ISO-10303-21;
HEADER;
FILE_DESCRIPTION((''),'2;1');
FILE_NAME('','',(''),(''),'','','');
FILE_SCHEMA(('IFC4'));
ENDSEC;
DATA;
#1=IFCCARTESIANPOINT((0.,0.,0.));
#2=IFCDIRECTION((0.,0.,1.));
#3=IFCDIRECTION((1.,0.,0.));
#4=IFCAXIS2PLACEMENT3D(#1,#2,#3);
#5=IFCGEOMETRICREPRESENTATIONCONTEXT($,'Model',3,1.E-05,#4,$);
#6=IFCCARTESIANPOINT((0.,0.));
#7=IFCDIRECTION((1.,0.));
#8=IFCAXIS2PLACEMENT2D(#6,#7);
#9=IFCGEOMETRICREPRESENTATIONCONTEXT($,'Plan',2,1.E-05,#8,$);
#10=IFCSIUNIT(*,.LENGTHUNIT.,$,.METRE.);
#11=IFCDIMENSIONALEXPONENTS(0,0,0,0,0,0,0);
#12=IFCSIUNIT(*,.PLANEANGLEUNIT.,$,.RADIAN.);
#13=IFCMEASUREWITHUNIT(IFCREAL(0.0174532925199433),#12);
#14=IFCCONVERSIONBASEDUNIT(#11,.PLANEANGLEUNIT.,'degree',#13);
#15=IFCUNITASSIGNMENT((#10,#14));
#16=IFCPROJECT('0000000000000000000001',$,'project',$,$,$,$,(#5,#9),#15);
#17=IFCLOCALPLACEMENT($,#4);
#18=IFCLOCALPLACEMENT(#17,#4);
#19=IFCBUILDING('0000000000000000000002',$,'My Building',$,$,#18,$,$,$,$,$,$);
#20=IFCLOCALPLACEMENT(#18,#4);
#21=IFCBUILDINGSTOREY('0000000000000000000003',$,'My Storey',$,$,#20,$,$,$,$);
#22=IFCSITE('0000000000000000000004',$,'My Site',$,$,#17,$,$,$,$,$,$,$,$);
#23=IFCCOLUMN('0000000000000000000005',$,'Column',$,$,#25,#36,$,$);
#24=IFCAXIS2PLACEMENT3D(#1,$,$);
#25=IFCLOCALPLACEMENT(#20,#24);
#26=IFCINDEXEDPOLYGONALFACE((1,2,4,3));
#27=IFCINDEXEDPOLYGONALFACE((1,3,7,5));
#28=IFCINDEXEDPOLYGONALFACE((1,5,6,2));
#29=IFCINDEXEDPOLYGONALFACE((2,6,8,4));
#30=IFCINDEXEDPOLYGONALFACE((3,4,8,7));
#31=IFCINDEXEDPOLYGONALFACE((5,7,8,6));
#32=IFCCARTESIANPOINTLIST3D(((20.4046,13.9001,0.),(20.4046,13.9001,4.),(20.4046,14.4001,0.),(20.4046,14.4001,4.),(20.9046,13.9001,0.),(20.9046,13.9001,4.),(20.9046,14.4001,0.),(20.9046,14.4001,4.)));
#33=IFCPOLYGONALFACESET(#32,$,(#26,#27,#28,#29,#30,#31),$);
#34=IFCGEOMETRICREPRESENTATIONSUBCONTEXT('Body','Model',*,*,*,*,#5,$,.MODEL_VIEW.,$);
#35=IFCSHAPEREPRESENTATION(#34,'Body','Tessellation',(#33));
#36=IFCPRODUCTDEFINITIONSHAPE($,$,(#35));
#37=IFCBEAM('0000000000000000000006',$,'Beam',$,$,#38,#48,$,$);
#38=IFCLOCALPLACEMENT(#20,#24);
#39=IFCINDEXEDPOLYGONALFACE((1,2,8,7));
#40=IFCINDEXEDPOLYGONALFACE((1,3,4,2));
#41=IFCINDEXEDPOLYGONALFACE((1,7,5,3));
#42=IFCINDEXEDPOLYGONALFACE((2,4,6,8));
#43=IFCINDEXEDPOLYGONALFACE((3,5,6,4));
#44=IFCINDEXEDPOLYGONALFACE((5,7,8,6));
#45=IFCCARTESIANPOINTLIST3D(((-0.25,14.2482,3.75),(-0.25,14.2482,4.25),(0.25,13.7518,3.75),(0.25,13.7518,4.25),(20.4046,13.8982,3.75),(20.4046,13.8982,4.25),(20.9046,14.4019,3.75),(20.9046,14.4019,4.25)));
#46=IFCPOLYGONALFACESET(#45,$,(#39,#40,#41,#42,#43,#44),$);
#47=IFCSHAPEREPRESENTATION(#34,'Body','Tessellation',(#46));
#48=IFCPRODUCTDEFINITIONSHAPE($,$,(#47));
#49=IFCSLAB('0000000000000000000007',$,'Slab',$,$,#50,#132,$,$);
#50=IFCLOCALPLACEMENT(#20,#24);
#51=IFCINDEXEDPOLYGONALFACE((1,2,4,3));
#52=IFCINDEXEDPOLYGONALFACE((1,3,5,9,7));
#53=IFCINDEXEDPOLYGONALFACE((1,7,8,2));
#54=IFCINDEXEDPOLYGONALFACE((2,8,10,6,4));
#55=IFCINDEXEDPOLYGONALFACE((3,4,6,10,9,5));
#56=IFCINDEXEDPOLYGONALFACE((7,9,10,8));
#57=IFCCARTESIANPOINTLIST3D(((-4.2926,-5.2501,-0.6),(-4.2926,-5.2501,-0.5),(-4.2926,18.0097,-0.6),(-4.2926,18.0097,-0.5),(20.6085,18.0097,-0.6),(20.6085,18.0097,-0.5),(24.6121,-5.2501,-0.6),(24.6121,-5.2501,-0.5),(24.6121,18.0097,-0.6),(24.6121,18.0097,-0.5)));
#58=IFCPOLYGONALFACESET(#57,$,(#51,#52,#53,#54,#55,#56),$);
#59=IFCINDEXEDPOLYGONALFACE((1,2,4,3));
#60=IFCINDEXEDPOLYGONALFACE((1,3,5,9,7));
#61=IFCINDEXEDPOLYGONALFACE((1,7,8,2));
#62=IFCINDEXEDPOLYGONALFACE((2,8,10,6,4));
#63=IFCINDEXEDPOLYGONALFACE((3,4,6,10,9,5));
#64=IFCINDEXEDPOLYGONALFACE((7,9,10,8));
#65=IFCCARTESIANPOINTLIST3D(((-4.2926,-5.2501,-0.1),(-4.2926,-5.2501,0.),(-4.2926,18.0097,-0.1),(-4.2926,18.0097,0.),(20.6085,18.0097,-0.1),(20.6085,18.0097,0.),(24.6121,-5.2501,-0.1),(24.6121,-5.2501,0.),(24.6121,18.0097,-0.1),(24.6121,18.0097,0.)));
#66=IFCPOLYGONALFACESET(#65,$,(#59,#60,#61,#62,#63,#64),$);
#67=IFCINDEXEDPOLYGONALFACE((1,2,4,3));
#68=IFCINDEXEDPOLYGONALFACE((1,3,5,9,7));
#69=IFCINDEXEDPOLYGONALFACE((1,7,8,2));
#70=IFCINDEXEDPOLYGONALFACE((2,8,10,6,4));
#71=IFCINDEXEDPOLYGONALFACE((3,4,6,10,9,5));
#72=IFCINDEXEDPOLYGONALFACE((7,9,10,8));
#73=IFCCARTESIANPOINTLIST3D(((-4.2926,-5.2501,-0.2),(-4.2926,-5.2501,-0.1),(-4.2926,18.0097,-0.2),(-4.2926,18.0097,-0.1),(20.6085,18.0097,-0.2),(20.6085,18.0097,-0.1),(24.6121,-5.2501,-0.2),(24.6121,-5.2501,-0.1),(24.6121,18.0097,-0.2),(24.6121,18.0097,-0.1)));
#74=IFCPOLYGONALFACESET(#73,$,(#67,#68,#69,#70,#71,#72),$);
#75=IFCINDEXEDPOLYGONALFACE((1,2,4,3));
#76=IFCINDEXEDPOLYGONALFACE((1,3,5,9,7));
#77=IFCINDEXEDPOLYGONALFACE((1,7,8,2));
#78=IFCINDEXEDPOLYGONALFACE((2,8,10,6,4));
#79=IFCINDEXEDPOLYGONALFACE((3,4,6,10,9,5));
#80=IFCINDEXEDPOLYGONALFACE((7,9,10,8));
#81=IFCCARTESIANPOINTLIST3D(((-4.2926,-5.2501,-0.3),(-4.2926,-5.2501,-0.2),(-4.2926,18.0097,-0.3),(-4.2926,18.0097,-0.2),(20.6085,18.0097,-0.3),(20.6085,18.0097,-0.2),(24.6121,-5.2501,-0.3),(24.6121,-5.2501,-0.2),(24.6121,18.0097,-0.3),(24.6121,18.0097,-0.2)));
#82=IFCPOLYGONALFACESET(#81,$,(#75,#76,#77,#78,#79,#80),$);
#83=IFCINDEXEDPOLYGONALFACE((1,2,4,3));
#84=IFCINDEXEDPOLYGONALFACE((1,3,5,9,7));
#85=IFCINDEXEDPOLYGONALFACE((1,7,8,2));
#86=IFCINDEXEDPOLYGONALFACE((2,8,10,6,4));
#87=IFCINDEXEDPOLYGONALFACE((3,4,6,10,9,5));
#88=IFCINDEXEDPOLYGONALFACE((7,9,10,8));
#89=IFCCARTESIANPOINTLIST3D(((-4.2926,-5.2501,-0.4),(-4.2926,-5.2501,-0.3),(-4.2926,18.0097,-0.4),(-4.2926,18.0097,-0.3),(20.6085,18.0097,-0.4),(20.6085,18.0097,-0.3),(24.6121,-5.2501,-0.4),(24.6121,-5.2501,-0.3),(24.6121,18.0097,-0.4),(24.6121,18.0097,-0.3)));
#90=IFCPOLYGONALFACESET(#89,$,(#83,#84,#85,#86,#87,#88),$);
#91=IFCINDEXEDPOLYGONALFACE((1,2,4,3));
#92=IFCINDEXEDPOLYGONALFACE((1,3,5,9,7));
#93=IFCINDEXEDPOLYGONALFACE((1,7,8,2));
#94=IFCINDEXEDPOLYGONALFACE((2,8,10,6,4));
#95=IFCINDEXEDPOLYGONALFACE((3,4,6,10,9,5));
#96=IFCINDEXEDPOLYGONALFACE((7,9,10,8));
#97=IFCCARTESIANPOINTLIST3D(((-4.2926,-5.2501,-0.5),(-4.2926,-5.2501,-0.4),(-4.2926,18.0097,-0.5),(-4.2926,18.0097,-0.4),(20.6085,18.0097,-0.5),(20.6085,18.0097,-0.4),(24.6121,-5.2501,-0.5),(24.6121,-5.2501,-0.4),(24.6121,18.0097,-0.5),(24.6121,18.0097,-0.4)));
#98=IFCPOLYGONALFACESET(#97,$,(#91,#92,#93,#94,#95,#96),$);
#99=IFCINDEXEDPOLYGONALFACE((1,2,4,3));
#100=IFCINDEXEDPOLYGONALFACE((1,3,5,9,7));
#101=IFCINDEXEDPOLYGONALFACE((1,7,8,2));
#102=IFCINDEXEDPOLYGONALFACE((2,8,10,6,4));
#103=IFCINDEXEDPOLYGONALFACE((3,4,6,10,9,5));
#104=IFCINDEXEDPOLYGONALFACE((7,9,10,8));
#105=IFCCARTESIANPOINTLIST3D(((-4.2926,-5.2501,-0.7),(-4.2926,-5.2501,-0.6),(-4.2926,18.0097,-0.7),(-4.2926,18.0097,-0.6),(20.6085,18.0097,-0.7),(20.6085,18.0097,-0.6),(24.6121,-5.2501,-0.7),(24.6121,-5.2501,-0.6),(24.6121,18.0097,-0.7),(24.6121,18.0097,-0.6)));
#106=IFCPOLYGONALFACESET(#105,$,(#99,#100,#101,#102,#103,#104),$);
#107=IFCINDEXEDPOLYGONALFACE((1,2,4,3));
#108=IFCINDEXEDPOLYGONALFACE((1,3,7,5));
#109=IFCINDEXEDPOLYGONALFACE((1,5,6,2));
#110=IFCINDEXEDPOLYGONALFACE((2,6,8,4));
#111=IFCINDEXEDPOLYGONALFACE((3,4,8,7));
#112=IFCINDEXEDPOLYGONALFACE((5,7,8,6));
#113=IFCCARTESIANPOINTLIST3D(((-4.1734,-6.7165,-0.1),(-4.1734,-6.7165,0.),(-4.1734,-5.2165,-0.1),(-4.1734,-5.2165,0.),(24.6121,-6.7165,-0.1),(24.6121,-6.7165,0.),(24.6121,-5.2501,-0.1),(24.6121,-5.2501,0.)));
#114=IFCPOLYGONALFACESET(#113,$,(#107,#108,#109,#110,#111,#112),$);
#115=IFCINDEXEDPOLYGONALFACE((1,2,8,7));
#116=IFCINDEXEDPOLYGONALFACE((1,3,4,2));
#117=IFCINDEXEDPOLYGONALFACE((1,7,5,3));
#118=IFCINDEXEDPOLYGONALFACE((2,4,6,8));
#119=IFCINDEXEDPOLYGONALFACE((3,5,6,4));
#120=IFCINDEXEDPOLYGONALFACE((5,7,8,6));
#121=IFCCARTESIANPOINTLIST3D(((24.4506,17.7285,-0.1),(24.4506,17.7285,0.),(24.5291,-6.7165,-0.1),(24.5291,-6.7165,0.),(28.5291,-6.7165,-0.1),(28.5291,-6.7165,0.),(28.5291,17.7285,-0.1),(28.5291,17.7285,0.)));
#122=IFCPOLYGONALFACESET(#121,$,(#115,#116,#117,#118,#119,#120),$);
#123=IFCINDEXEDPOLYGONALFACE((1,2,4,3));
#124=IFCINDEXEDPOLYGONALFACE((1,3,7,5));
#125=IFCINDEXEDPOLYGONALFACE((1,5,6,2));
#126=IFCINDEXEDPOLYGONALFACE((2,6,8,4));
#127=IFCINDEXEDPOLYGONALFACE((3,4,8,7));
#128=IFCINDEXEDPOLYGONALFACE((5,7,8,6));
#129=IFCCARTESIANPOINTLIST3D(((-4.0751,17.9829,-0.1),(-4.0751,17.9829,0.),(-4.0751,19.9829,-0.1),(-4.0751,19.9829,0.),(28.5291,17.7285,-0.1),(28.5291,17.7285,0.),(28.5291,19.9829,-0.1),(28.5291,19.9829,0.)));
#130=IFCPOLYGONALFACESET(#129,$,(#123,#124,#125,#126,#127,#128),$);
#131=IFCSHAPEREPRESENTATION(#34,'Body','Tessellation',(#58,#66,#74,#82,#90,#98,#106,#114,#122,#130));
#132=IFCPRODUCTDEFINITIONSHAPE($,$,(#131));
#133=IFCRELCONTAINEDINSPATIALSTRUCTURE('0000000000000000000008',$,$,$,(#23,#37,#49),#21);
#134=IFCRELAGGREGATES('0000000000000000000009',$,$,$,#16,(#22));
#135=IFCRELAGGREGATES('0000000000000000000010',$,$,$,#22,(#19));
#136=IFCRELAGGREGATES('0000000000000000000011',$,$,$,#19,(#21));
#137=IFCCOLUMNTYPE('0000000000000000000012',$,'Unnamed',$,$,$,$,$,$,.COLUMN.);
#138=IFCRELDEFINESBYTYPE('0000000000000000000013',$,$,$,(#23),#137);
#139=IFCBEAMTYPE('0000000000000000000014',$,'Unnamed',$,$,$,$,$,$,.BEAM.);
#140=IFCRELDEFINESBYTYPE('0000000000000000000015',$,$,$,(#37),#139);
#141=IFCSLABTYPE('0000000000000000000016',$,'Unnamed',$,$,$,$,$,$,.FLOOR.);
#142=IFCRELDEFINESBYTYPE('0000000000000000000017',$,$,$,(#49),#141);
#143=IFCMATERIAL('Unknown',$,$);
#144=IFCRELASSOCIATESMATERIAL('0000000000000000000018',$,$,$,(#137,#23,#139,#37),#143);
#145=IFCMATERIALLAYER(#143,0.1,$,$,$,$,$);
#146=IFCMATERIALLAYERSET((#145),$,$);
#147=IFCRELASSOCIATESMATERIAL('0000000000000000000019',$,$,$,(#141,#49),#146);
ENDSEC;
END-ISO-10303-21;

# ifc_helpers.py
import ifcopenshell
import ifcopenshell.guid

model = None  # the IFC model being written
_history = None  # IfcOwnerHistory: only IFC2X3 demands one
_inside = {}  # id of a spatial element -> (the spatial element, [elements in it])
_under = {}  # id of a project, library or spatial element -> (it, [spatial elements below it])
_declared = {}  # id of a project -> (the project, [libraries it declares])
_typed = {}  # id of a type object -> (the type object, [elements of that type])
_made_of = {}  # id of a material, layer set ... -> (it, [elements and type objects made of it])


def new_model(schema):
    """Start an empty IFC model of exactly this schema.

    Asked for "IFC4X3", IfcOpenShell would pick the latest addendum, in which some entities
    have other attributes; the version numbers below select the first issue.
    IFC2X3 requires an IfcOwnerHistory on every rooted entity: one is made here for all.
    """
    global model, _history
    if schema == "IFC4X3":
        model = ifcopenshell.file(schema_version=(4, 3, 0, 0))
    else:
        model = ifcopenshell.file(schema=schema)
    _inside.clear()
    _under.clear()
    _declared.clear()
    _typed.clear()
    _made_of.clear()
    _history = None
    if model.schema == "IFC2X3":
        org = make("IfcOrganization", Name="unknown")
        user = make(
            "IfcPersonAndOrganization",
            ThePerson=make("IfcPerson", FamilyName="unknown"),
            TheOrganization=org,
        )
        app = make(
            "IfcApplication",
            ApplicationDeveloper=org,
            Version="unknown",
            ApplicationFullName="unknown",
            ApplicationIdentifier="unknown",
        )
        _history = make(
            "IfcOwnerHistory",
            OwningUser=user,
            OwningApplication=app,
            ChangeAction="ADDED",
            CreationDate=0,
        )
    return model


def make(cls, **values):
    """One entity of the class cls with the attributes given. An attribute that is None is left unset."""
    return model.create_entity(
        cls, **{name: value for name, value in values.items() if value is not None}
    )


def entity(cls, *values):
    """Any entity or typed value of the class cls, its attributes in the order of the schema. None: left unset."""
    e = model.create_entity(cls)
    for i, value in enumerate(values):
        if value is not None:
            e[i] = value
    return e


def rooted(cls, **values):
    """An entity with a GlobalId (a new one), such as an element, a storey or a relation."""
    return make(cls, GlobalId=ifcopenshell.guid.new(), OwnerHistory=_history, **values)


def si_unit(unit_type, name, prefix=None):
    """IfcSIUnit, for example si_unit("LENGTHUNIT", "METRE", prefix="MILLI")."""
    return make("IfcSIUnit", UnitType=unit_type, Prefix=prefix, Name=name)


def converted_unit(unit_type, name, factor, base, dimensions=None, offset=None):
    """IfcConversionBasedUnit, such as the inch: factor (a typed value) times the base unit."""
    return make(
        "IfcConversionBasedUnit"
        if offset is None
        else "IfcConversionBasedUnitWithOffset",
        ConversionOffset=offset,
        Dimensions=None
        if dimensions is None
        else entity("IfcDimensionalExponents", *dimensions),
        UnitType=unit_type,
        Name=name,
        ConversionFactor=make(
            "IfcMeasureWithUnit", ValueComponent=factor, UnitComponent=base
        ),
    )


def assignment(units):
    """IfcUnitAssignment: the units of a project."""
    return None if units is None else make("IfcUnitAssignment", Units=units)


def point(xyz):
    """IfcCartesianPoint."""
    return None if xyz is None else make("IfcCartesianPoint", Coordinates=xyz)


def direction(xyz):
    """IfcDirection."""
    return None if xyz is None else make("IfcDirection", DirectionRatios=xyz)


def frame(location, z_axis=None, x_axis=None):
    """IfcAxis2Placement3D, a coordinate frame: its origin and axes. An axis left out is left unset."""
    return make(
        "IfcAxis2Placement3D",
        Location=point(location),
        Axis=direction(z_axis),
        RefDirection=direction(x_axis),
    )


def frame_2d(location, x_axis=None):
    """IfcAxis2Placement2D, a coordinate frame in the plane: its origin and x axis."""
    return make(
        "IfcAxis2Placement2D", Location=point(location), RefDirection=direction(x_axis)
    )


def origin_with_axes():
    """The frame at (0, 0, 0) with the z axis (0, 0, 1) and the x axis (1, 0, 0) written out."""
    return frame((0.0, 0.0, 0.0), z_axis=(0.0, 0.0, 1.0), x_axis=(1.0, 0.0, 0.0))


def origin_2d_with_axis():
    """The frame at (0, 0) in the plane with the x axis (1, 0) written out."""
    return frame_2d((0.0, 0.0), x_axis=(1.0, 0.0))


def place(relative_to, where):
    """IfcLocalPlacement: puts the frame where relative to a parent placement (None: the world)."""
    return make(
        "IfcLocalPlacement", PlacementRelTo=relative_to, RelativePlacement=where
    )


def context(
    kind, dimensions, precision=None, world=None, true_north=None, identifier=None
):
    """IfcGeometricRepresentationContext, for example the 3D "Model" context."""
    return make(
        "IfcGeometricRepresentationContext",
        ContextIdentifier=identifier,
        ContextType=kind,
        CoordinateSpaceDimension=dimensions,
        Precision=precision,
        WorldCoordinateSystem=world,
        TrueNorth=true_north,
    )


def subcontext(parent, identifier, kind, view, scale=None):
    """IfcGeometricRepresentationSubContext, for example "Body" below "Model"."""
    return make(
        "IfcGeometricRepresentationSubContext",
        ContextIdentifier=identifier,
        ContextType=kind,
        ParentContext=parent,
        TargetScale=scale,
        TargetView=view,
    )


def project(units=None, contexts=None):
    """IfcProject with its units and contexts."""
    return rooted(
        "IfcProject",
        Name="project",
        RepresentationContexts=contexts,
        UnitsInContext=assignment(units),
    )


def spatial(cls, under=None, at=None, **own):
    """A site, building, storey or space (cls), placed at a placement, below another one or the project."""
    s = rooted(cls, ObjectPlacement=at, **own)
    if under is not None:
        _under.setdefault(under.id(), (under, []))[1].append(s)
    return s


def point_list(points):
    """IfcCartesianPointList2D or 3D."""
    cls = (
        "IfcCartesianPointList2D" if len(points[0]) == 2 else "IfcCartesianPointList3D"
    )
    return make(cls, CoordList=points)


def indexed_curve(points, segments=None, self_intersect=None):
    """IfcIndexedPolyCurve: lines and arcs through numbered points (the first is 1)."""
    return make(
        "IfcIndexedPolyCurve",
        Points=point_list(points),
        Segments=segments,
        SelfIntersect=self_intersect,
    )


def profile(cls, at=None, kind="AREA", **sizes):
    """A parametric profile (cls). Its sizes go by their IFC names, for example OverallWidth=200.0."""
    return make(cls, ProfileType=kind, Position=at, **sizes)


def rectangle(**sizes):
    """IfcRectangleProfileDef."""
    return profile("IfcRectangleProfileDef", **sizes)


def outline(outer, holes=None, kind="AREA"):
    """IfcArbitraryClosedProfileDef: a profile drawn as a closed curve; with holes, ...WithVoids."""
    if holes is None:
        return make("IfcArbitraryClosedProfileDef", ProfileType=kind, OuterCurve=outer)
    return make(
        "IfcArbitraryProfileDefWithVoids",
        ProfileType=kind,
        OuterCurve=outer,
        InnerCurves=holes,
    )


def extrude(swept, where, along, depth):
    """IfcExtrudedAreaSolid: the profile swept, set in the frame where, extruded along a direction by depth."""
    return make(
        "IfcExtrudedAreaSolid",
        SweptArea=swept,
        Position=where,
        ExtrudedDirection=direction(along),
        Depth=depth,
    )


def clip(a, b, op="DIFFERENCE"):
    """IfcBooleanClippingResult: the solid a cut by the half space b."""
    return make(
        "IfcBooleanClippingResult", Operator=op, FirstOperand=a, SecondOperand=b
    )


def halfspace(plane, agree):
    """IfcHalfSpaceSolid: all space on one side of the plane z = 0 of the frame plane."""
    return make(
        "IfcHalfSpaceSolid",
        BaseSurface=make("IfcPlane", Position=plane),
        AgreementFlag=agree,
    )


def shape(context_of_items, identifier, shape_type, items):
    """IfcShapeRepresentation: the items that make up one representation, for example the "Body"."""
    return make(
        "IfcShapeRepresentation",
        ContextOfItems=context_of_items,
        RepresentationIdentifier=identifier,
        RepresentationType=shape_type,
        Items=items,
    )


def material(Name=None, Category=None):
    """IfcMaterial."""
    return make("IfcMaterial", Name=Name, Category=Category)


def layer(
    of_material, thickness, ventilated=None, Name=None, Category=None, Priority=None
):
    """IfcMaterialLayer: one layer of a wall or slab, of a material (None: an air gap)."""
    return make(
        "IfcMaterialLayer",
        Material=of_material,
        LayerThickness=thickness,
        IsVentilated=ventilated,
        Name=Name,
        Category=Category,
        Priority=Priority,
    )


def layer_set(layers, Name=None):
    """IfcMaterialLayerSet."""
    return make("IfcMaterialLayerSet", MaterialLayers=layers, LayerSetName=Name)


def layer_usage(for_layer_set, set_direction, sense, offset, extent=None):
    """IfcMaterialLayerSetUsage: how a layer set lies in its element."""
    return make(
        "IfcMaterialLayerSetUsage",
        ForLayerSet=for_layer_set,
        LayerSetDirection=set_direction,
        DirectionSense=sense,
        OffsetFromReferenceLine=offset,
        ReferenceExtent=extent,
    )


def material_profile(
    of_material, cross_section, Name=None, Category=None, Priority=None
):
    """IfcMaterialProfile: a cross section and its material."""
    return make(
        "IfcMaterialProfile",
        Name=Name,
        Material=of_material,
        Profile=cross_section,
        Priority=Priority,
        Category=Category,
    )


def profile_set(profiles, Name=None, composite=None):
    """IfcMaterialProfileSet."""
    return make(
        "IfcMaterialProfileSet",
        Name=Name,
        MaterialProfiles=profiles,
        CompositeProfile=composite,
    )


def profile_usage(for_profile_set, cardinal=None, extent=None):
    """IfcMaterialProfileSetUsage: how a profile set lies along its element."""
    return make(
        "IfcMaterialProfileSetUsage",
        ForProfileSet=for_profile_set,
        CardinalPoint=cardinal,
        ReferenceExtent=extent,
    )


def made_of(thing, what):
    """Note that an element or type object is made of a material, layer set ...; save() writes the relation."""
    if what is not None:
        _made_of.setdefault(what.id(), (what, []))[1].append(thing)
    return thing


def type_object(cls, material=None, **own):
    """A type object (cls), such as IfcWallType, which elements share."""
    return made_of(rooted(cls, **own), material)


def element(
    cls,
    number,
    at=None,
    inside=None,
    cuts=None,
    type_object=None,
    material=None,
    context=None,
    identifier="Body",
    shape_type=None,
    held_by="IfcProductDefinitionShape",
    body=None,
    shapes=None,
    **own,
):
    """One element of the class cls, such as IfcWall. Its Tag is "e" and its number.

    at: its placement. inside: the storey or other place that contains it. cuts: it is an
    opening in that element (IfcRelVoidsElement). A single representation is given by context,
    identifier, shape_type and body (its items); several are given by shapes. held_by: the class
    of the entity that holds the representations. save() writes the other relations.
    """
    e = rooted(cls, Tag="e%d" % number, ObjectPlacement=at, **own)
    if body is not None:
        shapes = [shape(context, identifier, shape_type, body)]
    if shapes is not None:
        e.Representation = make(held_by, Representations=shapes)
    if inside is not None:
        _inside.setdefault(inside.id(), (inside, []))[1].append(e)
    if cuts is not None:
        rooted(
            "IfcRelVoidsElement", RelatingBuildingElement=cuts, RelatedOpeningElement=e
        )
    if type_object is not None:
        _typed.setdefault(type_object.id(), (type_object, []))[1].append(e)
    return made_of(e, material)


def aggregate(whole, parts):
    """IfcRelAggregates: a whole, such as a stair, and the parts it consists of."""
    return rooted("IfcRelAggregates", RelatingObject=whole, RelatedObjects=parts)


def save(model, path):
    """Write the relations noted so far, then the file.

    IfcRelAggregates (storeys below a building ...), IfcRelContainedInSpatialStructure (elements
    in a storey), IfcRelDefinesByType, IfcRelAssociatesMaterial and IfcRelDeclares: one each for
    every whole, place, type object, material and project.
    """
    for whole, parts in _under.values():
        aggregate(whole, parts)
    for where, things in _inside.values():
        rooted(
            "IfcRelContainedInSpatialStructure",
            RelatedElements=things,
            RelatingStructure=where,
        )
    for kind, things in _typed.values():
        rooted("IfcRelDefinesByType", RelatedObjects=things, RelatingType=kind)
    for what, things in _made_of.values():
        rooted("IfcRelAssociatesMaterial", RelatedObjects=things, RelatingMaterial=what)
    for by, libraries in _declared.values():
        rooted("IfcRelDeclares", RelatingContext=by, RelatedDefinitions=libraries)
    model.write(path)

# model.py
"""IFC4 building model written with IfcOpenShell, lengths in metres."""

from ifc_helpers import new_model, entity, si_unit, converted_unit, frame, origin_with_axes, origin_2d_with_axis, place, context, subcontext, project, spatial, indexed_curve, rectangle, outline, extrude, clip, halfspace, material, layer, layer_set, layer_usage, material_profile, profile_set, profile_usage, type_object, element, save


model = new_model("IFC4")

# Units and contexts
model_context = context("Model", 3, precision=1e-05, world=origin_with_axes())
plan_context = context("Plan", 2, precision=1e-05, world=origin_2d_with_axis())
body_context_1 = subcontext(model_context, "Body", "Model", "MODEL_VIEW")
ifc_project = project(units=[si_unit("LENGTHUNIT", "METRE"), converted_unit("PLANEANGLEUNIT", "degree", entity("IfcReal", 0.0174532925199433), si_unit("PLANEANGLEUNIT", "RADIAN"), dimensions=[0, 0, 0, 0, 0, 0, 0])], contexts=[model_context, plan_context])

# Site, building, storey
site_placement = place(None, origin_with_axes())
site = spatial("IfcSite", under=ifc_project, at=site_placement, Name="My Site")
building_placement = place(site_placement, origin_with_axes())
building = spatial("IfcBuilding", under=site, at=building_placement, Name="My Building")
storey_placement = place(building_placement, origin_with_axes())
storey = spatial("IfcBuildingStorey", under=building, at=storey_placement, Name="My Storey")

# Column
ifc_material = material(Name="Unknown")
ifc_material_profile_1 = material_profile(ifc_material, rectangle(XDim=0.5, YDim=0.5))
ifc_profile_set_1 = profile_set([ifc_material_profile_1])
ifc_profile_usage_1 = profile_usage(ifc_profile_set_1, cardinal=5)
column_type = type_object("IfcColumnType", Name="Unnamed", PredefinedType="COLUMN", material=ifc_profile_set_1)
column_placement = place(storey_placement, frame((20.6546, 14.1501, 0.0), z_axis=(0.0, 0.0, 1.0), x_axis=(1.0, 0.0, 0.0)))
element("IfcColumn", 1, at=column_placement, inside=storey, type_object=column_type, material=ifc_profile_usage_1, Name="Column", context=body_context_1, shape_type="SweptSolid", body=[
    extrude(rectangle(XDim=0.5, YDim=0.5), origin_with_axes(), (0.0, 0.0, 1.0), 4.0),
])

# Beam
ifc_material_profile_2 = material_profile(ifc_material, rectangle(XDim=0.5, YDim=0.5))
ifc_profile_set_2 = profile_set([ifc_material_profile_2])
ifc_profile_usage_2 = profile_usage(ifc_profile_set_2, cardinal=5)
beam_type = type_object("IfcBeamType", Name="Unnamed", PredefinedType="BEAM", material=ifc_profile_set_2)
beam_placement = place(storey_placement, frame((21.4046, 14.1555, 4.0), z_axis=(-0.999974, -0.007265, 0.0), x_axis=(0.007265, -0.999974, 0.0)))
element("IfcBeam", 2, at=beam_placement, inside=storey, type_object=beam_type, material=ifc_profile_usage_2, Name="Beam", context=body_context_1, shape_type="Clipping", body=[
    clip(clip(extrude(rectangle(XDim=0.5, YDim=0.5), origin_with_axes(), (0.0, 0.0, 1.0), 22.1552), halfspace(frame((-0.25, -4.0, 21.6534), z_axis=(0.704534, 0.0, 0.709671), x_axis=(0.0, -1.0, 0.0)), False)), halfspace(frame((-0.25, -4.0, 0.4982), z_axis=(0.709672, 0.0, -0.704533), x_axis=(0.0, -1.0, 0.0)), False)),
])

# Slab
ifc_layer_1 = layer(ifc_material, 0.1)
ifc_layer_set_1 = layer_set([ifc_layer_1])
ifc_layer_usage_1 = layer_usage(ifc_layer_set_1, "AXIS3", "POSITIVE", -0.1)
slab_type = type_object("IfcSlabType", Name="Unnamed", PredefinedType="FLOOR", material=ifc_layer_set_1)
slab_placement = place(storey_placement, frame((20.6085, 18.0097, -0.5), z_axis=(0.0, 0.0, 1.0), x_axis=(1.0, 0.0, 0.0)))
element("IfcSlab", 3, at=slab_placement, inside=storey, type_object=slab_type, material=ifc_layer_usage_1, Name="Slab", context=body_context_1, shape_type="SweptSolid", body=[
    extrude(outline(indexed_curve([(0.0, 0.0), (-24.9011, 0.0), (-24.9011, -23.2598), (4.0035, -23.2598), (4.0036, 0.0), (0.0, 0.0)])), frame((0.0, 0.0, -0.1), z_axis=(0.0, 0.0, 1.0), x_axis=(1.0, 0.0, 0.0)), (0.0, 0.0, 1.0), 0.1),
    extrude(outline(indexed_curve([(0.0, 0.0), (-24.9011, 0.0), (-24.9011, -23.2598), (4.0035, -23.2598), (4.0036, 0.0), (0.0, 0.0)])), frame((0.0, 0.0, 0.4), z_axis=(0.0, 0.0, 1.0), x_axis=(1.0, 0.0, 0.0)), (0.0, 0.0, 1.0), 0.1),
    extrude(outline(indexed_curve([(0.0, 0.0), (-24.9011, 0.0), (-24.9011, -23.2598), (4.0035, -23.2598), (4.0036, 0.0), (0.0, 0.0)])), frame((0.0, 0.0, 0.3), z_axis=(0.0, 0.0, 1.0), x_axis=(1.0, 0.0, 0.0)), (0.0, 0.0, 1.0), 0.1),
    extrude(outline(indexed_curve([(0.0, 0.0), (-24.9011, 0.0), (-24.9011, -23.2598), (4.0035, -23.2598), (4.0036, 0.0), (0.0, 0.0)])), frame((0.0, 0.0, 0.2), z_axis=(0.0, 0.0, 1.0), x_axis=(1.0, 0.0, 0.0)), (0.0, 0.0, 1.0), 0.1),
    extrude(outline(indexed_curve([(0.0, 0.0), (-24.9011, 0.0), (-24.9011, -23.2598), (4.0035, -23.2598), (4.0036, 0.0), (0.0, 0.0)])), frame((0.0, 0.0, 0.1), z_axis=(0.0, 0.0, 1.0), x_axis=(1.0, 0.0, 0.0)), (0.0, 0.0, 1.0), 0.1),
    extrude(outline(indexed_curve([(0.0, 0.0), (-24.9011, 0.0), (-24.9011, -23.2598), (4.0035, -23.2598), (4.0036, 0.0), (0.0, 0.0)])), frame((0.0, 0.0, 0.0), z_axis=(0.0, 0.0, 1.0), x_axis=(1.0, 0.0, 0.0)), (0.0, 0.0, 1.0), 0.1),
    extrude(outline(indexed_curve([(0.0, 0.0), (-24.9011, 0.0), (-24.9011, -23.2598), (4.0035, -23.2598), (4.0036, 0.0), (0.0, 0.0)])), frame((0.0, 0.0, -0.2), z_axis=(0.0, 0.0, 1.0), x_axis=(1.0, 0.0, 0.0)), (0.0, 0.0, 1.0), 0.1),
    extrude(outline(indexed_curve([(0.0, 0.0), (0.0, -1.5), (28.7854, -1.5), (28.7854, -0.0335), (0.0, 0.0)])), frame((-24.7819, -23.2262, 0.4), z_axis=(0.0, 0.0, 1.0), x_axis=(1.0, 0.0, 0.0)), (0.0, 0.0, 1.0), 0.1),
    extrude(outline(indexed_curve([(0.0, 0.0), (4.0, 0.0), (4.0, 24.445), (-0.0785, 24.445), (0.0, 0.0)])), frame((3.9206, -24.7262, 0.4), z_axis=(0.0, 0.0, 1.0), x_axis=(1.0, 0.0, 0.0)), (0.0, 0.0, 1.0), 0.1),
    extrude(outline(indexed_curve([(0.0, 0.0), (0.0, 2.0), (32.6041, 2.0), (32.6041, -0.2544), (0.0, 0.0)])), frame((-24.6836, -0.0268, 0.4), z_axis=(0.0, 0.0, 1.0), x_axis=(1.0, 0.0, 0.0)), (0.0, 0.0, 1.0), 0.1),
])

save(model, "model.ifc")
